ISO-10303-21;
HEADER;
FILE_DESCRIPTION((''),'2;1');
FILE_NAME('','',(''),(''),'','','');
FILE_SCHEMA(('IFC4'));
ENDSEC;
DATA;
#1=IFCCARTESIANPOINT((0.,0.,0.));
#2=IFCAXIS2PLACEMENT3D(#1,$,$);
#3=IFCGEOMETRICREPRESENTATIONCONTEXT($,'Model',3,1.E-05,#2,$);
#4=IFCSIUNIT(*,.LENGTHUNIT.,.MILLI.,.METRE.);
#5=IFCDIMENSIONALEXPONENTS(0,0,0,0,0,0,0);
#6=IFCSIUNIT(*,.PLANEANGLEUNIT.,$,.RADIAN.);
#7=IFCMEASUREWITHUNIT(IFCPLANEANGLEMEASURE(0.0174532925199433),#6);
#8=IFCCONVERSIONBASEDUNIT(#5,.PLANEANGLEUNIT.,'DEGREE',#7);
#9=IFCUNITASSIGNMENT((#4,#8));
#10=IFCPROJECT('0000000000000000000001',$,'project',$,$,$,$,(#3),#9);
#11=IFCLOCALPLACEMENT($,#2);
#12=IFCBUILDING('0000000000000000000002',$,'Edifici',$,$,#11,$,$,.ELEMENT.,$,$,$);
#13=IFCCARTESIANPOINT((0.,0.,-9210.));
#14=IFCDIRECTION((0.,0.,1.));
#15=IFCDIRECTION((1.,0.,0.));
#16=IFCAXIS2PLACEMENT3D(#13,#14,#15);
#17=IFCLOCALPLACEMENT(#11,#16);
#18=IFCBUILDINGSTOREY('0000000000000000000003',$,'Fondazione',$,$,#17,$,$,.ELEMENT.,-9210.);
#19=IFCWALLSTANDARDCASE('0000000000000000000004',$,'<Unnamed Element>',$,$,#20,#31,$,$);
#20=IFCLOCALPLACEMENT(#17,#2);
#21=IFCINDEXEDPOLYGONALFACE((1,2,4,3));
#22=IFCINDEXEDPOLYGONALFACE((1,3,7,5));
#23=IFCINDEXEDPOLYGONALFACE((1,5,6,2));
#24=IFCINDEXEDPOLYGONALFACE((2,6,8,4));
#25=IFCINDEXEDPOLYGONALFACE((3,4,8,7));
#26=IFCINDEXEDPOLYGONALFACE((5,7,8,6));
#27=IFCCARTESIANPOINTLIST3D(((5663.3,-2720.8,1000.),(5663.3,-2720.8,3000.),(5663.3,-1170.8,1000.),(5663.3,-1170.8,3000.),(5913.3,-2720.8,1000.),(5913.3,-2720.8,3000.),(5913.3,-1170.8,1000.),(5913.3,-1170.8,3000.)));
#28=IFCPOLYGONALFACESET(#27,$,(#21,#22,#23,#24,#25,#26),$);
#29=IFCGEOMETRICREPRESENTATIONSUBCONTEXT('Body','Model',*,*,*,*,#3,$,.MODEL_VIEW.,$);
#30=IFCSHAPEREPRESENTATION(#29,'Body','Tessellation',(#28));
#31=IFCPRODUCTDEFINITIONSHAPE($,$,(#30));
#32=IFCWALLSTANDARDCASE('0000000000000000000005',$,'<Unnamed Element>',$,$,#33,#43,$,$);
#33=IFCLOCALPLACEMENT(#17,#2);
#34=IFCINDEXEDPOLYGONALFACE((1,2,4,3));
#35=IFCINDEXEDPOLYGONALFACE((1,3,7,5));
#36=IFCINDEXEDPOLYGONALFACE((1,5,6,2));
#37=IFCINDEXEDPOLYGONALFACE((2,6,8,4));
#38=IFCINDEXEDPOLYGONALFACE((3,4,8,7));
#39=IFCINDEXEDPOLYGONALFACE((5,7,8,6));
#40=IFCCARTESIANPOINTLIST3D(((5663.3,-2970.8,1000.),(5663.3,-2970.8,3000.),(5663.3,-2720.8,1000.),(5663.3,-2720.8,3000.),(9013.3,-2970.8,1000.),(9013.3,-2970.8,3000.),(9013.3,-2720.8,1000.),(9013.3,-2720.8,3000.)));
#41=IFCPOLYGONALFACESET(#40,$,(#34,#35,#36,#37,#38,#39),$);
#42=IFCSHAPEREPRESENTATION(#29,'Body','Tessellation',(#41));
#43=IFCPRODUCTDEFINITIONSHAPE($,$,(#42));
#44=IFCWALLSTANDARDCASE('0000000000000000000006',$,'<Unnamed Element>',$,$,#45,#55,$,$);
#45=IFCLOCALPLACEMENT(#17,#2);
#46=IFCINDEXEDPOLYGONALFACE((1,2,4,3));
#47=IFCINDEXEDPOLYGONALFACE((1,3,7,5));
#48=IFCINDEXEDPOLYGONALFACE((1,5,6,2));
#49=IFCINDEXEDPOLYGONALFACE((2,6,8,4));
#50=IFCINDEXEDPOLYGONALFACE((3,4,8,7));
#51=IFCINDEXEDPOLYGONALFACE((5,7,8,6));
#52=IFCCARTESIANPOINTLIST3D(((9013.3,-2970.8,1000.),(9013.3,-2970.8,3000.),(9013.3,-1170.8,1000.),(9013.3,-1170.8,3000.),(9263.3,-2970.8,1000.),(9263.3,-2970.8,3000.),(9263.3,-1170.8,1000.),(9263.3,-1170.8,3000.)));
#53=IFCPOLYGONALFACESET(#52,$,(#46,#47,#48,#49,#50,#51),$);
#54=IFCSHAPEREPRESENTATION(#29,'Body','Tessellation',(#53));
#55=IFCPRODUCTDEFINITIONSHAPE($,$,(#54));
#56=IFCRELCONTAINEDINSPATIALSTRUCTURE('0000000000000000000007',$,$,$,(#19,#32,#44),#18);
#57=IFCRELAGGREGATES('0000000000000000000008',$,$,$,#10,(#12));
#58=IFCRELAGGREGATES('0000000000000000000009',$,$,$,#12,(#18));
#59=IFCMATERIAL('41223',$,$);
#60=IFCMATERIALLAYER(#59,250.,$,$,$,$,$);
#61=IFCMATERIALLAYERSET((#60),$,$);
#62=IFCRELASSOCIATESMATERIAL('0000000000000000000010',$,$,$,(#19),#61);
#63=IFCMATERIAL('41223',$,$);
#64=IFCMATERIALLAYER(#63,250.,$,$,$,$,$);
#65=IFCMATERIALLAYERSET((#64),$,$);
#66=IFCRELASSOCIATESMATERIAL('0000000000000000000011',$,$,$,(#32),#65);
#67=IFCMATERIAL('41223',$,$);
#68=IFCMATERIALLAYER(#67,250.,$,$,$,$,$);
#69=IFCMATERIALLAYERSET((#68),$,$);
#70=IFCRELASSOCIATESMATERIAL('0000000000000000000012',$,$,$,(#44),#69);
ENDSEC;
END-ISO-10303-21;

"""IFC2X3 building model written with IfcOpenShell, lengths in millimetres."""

from ifc_helpers import new_model, entity, si_unit, converted_unit, frame, frame_2d, origin, origin_with_axes, place, context, subcontext, project, spatial, rectangle, extrude, material, layer, layer_set, layer_usage, element, save


model = new_model("IFC2X3")

# Units and contexts
model_context = context("Model", 3, precision=1e-05, world=origin())
body_context = subcontext(model_context, "Body", "Model", "MODEL_VIEW")
ifc_project = project(units=[si_unit("LENGTHUNIT", "METRE", prefix="MILLI"), converted_unit("PLANEANGLEUNIT", "DEGREE", entity("IfcPlaneAngleMeasure", 0.0174532925199433), si_unit("PLANEANGLEUNIT", "RADIAN"), dimensions=[0, 0, 0, 0, 0, 0, 0])], contexts=[model_context])

# Building, storey
building_placement = place(None, origin())
building = spatial("IfcBuilding", under=ifc_project, at=building_placement, Name="Edifici", CompositionType="ELEMENT")
storey_placement = place(building_placement, frame((0.0, 0.0, -9210.0), z_axis=(0.0, 0.0, 1.0), x_axis=(1.0, 0.0, 0.0)))
storey = spatial("IfcBuildingStorey", under=building, at=storey_placement, Name="Fondazione", CompositionType="ELEMENT", Elevation=-9210.0)

# Walls
ifc_material_1 = material(Name="41223")
ifc_layer_1 = layer(ifc_material_1, 250.0)
ifc_layer_set_1 = layer_set([ifc_layer_1])
ifc_layer_usage_1 = layer_usage(ifc_layer_set_1, "AXIS2", "POSITIVE", 0.0)
wall_1_placement = place(storey_placement, frame((5663.3, -1170.8, 1000.0), z_axis=(0.0, 0.0, 1.0), x_axis=(0.0, -1.0, 0.0)))
element("IfcWallStandardCase", 1, at=wall_1_placement, inside=storey, material=ifc_layer_usage_1, Name="<Unnamed Element>", context=body_context, shape_type="SweptSolid", body=[
    extrude(rectangle(XDim=1550.0, YDim=250.0, at=frame_2d((775.0, 125.0), x_axis=(1.0, 0.0))), origin_with_axes(), (0.0, 0.0, 1.0), 2000.0),
])
ifc_material_2 = material(Name="41223")
ifc_layer_2 = layer(ifc_material_2, 250.0)
ifc_layer_set_2 = layer_set([ifc_layer_2])
ifc_layer_usage_2 = layer_usage(ifc_layer_set_2, "AXIS2", "POSITIVE", 0.0)
wall_2_placement = place(storey_placement, frame((5663.3, -2970.8, 1000.0), z_axis=(0.0, 0.0, 1.0), x_axis=(1.0, 0.0, 0.0)))
element("IfcWallStandardCase", 2, at=wall_2_placement, inside=storey, material=ifc_layer_usage_2, Name="<Unnamed Element>", context=body_context, shape_type="SweptSolid", body=[
    extrude(rectangle(XDim=3350.0, YDim=250.0, at=frame_2d((1675.0, 125.0), x_axis=(1.0, 0.0))), origin_with_axes(), (0.0, 0.0, 1.0), 2000.0),
])
ifc_material_3 = material(Name="41223")
ifc_layer_3 = layer(ifc_material_3, 250.0)
ifc_layer_set_3 = layer_set([ifc_layer_3])
ifc_layer_usage_3 = layer_usage(ifc_layer_set_3, "AXIS2", "POSITIVE", 0.0)
wall_3_placement = place(storey_placement, frame((9263.3, -2970.8, 1000.0), z_axis=(0.0, 0.0, 1.0), x_axis=(0.0, 1.0, 0.0)))
element("IfcWallStandardCase", 3, at=wall_3_placement, inside=storey, material=ifc_layer_usage_3, Name="<Unnamed Element>", context=body_context, shape_type="SweptSolid", body=[
    extrude(rectangle(XDim=1800.0, YDim=250.0, at=frame_2d((900.0, 125.0), x_axis=(1.0, 0.0))), origin_with_axes(), (0.0, 0.0, 1.0), 2000.0),
])

save(model, "model.ifc")
